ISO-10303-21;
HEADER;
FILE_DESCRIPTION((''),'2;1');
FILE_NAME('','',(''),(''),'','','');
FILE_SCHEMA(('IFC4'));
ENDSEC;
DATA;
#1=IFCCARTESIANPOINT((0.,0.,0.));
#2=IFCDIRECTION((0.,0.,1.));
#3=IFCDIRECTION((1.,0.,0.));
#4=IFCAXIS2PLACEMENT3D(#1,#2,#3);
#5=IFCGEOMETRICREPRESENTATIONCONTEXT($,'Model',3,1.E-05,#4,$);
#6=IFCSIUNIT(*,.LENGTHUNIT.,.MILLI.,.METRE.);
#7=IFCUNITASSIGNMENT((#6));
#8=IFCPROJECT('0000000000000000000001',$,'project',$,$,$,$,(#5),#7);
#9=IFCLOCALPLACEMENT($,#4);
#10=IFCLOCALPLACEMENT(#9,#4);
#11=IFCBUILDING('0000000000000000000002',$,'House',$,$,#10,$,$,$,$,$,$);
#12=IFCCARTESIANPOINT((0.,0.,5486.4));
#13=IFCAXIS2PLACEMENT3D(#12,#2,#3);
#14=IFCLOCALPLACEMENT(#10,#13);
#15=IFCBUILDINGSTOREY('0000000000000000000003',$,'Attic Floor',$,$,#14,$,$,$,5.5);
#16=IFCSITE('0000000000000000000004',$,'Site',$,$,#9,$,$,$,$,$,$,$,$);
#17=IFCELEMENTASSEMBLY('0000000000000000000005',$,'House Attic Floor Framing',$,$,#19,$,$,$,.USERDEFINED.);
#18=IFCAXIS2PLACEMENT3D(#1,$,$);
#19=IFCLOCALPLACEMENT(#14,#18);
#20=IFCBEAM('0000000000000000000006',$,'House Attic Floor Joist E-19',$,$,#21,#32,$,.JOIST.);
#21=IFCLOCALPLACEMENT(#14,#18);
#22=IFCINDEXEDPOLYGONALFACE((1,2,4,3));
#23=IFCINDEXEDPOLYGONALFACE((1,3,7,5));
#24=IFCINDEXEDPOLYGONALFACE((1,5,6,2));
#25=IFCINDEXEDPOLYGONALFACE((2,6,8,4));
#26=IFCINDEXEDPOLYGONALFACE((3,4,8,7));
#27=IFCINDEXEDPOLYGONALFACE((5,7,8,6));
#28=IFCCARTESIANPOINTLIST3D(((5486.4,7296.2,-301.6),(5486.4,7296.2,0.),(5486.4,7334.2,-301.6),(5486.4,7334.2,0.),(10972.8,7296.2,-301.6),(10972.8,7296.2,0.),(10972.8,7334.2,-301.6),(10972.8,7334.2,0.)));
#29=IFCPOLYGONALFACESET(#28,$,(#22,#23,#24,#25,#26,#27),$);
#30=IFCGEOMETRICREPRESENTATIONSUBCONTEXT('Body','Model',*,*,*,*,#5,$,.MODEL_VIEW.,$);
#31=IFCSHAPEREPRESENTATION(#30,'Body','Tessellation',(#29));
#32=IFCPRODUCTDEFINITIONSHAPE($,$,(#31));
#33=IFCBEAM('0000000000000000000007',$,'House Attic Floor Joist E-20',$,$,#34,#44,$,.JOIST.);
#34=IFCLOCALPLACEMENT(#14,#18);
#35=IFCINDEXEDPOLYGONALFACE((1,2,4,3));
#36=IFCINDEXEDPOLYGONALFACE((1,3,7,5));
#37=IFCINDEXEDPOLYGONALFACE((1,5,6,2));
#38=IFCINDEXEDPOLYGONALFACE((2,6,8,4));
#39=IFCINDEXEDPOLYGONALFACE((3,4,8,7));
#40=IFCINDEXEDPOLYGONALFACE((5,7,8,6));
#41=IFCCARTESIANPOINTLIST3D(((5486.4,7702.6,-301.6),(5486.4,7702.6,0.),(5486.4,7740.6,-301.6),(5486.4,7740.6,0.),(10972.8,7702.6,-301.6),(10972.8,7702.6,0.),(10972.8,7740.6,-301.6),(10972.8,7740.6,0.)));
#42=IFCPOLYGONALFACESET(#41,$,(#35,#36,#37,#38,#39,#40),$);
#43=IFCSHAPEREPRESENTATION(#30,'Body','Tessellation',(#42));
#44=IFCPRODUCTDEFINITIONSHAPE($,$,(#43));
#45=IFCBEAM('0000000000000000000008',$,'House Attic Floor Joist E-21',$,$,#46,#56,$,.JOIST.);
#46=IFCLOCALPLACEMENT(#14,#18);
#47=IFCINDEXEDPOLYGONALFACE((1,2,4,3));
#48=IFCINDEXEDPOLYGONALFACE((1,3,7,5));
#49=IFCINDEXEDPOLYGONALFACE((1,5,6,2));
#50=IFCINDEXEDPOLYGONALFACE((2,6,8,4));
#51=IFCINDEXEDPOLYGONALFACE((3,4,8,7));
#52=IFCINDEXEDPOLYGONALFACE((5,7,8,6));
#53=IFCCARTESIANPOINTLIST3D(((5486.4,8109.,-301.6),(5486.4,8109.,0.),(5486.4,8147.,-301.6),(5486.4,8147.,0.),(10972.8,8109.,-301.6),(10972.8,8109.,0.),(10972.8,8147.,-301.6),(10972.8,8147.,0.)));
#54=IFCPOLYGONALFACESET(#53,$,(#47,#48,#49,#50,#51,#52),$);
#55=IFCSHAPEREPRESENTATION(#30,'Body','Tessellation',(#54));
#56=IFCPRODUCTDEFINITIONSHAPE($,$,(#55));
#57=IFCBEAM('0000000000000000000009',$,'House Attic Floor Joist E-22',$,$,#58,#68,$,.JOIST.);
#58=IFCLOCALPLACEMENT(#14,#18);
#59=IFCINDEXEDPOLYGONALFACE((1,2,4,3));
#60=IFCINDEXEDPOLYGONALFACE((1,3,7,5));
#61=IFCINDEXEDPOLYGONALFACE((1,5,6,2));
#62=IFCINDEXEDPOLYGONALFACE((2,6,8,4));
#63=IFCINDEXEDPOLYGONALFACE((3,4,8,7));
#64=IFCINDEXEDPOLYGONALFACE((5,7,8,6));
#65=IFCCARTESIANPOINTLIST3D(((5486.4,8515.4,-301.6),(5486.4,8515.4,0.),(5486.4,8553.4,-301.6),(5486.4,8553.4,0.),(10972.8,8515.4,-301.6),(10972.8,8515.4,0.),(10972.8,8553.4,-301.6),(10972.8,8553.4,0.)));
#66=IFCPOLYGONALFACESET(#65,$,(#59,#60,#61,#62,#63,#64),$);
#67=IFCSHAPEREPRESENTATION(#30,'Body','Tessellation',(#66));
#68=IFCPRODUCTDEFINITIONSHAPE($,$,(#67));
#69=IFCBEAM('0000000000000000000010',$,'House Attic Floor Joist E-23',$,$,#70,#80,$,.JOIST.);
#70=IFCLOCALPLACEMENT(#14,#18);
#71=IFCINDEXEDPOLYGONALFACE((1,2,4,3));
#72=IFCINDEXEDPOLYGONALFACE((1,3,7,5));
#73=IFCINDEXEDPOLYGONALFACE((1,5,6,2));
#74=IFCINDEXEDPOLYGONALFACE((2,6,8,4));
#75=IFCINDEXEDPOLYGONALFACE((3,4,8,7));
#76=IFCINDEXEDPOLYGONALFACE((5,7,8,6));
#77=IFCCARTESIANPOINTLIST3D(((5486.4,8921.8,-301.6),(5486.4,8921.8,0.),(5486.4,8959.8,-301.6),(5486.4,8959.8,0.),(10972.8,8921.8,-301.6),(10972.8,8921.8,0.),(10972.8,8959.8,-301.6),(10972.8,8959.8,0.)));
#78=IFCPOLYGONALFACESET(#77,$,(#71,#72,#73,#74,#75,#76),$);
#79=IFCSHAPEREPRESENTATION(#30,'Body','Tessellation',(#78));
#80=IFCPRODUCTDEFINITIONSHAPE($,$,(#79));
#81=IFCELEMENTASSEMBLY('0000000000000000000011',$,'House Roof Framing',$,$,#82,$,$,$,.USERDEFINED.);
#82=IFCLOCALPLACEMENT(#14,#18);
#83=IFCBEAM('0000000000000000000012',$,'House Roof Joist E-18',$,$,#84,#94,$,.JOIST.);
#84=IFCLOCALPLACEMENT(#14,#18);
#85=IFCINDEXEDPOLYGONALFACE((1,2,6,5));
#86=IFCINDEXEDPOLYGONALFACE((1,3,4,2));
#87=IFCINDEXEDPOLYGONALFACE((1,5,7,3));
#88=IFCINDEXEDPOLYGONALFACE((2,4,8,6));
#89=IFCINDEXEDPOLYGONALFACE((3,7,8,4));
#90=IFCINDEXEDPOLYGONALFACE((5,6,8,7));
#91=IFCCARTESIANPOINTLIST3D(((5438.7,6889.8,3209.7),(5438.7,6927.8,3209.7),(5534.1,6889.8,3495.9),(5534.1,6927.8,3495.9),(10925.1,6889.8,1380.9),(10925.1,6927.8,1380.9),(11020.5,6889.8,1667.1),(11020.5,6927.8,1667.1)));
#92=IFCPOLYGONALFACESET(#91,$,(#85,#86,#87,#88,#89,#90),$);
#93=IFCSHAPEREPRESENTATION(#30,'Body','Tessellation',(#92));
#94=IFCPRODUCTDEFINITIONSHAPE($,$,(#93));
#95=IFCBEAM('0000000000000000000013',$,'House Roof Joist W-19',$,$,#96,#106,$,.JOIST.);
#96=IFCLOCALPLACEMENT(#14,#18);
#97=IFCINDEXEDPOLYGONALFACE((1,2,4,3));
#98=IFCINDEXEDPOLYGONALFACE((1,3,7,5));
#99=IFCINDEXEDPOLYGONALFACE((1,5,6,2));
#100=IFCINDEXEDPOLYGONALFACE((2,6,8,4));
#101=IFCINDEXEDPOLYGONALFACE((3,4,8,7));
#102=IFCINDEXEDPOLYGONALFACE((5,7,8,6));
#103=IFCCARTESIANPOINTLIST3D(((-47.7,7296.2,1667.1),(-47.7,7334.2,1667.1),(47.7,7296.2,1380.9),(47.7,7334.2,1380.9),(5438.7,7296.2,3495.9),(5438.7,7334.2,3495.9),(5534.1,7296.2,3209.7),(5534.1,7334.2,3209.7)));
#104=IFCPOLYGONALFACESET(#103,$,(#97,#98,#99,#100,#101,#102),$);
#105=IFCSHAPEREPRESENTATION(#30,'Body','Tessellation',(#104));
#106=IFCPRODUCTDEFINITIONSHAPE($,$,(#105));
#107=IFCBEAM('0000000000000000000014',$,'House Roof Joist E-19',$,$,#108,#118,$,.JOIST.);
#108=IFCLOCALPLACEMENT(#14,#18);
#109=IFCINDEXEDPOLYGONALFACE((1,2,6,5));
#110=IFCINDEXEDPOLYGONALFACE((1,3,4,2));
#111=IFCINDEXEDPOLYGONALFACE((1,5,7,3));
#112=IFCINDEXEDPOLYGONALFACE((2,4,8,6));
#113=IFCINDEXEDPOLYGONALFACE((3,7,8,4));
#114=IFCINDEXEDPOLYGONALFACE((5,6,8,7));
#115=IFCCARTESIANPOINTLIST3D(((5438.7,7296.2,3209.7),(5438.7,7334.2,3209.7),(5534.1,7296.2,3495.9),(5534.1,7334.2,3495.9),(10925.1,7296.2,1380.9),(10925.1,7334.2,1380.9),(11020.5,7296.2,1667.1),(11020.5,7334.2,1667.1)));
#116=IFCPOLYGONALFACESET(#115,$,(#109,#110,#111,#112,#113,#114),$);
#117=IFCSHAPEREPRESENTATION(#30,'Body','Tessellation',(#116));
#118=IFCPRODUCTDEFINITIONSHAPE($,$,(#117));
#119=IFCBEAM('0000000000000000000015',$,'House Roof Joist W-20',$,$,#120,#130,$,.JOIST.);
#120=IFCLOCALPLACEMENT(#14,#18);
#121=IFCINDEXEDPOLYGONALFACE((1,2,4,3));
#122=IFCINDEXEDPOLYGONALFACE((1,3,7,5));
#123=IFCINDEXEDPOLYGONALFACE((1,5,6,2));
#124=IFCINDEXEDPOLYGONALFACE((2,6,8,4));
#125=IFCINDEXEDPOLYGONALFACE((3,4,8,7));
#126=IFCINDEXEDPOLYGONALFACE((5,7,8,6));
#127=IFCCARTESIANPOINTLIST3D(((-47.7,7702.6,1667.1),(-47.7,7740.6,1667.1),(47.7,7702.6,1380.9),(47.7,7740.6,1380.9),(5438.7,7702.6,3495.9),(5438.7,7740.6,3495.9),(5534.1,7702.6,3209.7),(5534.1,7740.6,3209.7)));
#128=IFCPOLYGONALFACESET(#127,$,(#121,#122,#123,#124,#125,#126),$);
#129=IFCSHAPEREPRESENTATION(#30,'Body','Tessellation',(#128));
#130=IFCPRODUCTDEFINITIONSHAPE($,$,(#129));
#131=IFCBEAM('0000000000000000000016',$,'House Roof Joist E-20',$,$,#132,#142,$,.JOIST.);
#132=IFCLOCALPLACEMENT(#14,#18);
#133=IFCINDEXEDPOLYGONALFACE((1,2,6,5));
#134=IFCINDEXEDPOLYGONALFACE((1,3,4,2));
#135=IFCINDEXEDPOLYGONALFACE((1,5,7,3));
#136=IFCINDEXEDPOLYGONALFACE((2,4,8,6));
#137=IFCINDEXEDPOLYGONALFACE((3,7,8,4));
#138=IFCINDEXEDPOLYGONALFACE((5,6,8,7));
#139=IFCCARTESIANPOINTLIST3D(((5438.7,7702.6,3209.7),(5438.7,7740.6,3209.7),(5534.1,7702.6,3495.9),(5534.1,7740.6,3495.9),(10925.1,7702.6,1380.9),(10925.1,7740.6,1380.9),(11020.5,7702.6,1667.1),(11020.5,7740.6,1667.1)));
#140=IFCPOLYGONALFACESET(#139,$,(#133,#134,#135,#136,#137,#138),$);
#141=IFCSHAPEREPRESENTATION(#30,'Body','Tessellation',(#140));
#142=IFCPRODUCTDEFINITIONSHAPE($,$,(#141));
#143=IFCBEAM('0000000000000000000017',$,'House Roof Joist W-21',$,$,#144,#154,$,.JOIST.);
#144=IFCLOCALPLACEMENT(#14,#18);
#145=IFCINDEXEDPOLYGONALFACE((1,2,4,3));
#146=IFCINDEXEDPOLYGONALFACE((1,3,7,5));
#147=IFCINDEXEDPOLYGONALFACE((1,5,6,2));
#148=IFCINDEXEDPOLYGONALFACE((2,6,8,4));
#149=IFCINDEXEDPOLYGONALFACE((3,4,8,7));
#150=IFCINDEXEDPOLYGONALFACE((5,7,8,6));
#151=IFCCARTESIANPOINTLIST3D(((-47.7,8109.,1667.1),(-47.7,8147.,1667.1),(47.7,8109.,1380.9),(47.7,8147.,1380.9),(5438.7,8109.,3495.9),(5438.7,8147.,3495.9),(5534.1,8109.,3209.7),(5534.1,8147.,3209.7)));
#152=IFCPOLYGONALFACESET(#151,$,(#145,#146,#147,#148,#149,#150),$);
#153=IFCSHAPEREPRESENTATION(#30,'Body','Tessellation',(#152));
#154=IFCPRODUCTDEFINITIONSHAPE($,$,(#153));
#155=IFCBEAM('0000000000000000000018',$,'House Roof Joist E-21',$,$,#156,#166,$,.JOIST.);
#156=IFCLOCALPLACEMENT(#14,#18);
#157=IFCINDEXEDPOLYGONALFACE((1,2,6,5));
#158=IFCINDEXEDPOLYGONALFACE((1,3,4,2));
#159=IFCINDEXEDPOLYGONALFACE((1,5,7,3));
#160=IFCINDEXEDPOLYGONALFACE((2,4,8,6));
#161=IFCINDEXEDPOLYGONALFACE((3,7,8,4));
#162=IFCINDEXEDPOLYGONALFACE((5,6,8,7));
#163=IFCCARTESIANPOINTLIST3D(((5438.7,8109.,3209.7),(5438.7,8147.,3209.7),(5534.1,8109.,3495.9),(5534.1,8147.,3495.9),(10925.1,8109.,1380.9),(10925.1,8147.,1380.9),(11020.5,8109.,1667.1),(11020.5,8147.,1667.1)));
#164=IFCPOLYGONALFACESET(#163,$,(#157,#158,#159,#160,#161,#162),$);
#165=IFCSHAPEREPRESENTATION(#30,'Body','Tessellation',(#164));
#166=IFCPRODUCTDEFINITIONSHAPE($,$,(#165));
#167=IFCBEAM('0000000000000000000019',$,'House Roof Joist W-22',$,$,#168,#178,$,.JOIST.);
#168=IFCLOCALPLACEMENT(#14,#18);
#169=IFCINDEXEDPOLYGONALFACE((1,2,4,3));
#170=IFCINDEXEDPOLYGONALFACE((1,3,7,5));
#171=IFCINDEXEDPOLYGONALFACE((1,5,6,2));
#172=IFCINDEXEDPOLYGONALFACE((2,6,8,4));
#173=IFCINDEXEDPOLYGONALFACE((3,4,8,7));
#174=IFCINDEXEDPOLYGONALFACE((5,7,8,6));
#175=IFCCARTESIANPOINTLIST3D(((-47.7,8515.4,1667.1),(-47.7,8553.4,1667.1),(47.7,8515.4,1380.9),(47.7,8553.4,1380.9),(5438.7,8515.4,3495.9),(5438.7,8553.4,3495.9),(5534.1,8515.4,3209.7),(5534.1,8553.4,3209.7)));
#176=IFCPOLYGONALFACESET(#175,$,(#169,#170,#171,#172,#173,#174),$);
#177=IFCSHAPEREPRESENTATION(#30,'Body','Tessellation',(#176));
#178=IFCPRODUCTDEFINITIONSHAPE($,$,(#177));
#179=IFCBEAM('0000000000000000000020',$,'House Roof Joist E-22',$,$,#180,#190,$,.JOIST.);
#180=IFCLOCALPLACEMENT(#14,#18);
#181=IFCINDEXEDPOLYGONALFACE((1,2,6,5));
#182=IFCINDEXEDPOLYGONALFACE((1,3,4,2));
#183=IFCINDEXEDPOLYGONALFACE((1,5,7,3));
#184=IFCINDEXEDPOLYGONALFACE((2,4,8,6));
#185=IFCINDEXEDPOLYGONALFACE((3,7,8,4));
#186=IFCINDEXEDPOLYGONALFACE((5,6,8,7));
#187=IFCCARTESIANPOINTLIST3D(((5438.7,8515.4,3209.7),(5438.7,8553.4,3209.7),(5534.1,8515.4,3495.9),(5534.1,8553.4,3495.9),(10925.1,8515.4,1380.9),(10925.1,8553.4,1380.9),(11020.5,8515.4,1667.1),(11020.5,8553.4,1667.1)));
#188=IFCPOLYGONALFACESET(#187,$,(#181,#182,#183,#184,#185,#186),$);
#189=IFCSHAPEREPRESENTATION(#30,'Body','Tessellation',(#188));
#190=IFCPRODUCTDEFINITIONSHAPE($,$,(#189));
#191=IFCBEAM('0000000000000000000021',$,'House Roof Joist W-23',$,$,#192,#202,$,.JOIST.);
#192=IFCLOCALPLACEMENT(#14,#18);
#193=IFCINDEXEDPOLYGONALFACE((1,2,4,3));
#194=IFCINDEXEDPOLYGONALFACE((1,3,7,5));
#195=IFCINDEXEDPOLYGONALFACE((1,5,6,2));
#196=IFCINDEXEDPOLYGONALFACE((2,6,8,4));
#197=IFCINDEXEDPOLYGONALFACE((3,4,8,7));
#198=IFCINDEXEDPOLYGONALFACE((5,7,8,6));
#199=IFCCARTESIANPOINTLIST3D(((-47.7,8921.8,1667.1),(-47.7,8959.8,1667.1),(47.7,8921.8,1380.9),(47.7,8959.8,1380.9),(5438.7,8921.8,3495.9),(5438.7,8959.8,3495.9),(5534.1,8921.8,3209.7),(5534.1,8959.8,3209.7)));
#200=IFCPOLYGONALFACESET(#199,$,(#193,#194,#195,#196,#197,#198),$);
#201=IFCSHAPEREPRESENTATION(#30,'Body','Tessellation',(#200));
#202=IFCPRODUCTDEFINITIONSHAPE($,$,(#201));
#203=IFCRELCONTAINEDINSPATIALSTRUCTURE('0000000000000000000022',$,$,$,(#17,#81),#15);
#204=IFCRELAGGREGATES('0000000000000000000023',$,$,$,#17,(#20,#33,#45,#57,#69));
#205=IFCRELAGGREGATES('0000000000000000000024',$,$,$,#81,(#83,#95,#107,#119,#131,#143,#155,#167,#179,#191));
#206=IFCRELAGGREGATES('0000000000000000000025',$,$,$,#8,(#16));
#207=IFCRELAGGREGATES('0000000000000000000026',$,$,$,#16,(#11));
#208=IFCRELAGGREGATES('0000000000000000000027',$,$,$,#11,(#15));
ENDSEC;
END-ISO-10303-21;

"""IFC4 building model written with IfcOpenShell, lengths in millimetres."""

from ifc_helpers import new_model, si_unit, frame, origin_with_axes, origin_2d, place, context, subcontext, project, spatial, rectangle, extrude, element, aggregate, save


model = new_model("IFC4")

# Units and contexts
model_context = context("Model", 3, precision=1e-05, world=origin_with_axes())
body_context = subcontext(model_context, "Body", "Model", "MODEL_VIEW")
ifc_project = project(units=[si_unit("LENGTHUNIT", "METRE", prefix="MILLI")], contexts=[model_context])

# Site, building, storey
site_placement = place(None, origin_with_axes())
site = spatial("IfcSite", under=ifc_project, at=site_placement, Name="Site")
building_placement = place(site_placement, origin_with_axes())
building = spatial("IfcBuilding", under=site, at=building_placement, Name="House")
storey_placement = place(building_placement, frame((0.0, 0.0, 5486.4), z_axis=(0.0, 0.0, 1.0), x_axis=(1.0, 0.0, 0.0)))
storey = spatial("IfcBuildingStorey", under=building, at=storey_placement, Name="Attic Floor", Elevation=5.5)

# Element assemblies, beams
assembly_1_placement = place(storey_placement, frame((0.0, 0.0, -5486.4), z_axis=(0.0, 0.0, 1.0), x_axis=(1.0, 0.0, 0.0)))
assembly_1 = element("IfcElementAssembly", 1, at=assembly_1_placement, inside=storey, Name="House Attic Floor Framing", PredefinedType="USERDEFINED")
beam_1_placement = place(assembly_1_placement, frame((5486.4, 7315.2, 5335.6), z_axis=(1.0, 0.0, 0.0), x_axis=(0.0, 1.0, 0.0)))
beam_1 = element("IfcBeam", 2, at=beam_1_placement, Name="House Attic Floor Joist E-19", PredefinedType="JOIST", context=body_context, shape_type="SweptSolid", body=[
    extrude(rectangle(XDim=38.1, YDim=301.6, at=origin_2d()), origin_with_axes(), (0.0, 0.0, 1.0), 5486.4),
])
beam_2_placement = place(assembly_1_placement, frame((5486.4, 7721.6, 5335.6), z_axis=(1.0, 0.0, 0.0), x_axis=(0.0, 1.0, 0.0)))
beam_2 = element("IfcBeam", 3, at=beam_2_placement, Name="House Attic Floor Joist E-20", PredefinedType="JOIST", context=body_context, shape_type="SweptSolid", body=[
    extrude(rectangle(XDim=38.1, YDim=301.6, at=origin_2d()), origin_with_axes(), (0.0, 0.0, 1.0), 5486.4),
])
beam_3_placement = place(assembly_1_placement, frame((5486.4, 8128.0, 5335.6), z_axis=(1.0, 0.0, 0.0), x_axis=(0.0, 1.0, 0.0)))
beam_3 = element("IfcBeam", 4, at=beam_3_placement, Name="House Attic Floor Joist E-21", PredefinedType="JOIST", context=body_context, shape_type="SweptSolid", body=[
    extrude(rectangle(XDim=38.1, YDim=301.6, at=origin_2d()), origin_with_axes(), (0.0, 0.0, 1.0), 5486.4),
])
beam_4_placement = place(assembly_1_placement, frame((5486.4, 8534.4, 5335.6), z_axis=(1.0, 0.0, 0.0), x_axis=(0.0, 1.0, 0.0)))
beam_4 = element("IfcBeam", 5, at=beam_4_placement, Name="House Attic Floor Joist E-22", PredefinedType="JOIST", context=body_context, shape_type="SweptSolid", body=[
    extrude(rectangle(XDim=38.1, YDim=301.6, at=origin_2d()), origin_with_axes(), (0.0, 0.0, 1.0), 5486.4),
])
beam_5_placement = place(assembly_1_placement, frame((5486.4, 8940.8, 5335.6), z_axis=(1.0, 0.0, 0.0), x_axis=(0.0, 1.0, 0.0)))
beam_5 = element("IfcBeam", 6, at=beam_5_placement, Name="House Attic Floor Joist E-23", PredefinedType="JOIST", context=body_context, shape_type="SweptSolid", body=[
    extrude(rectangle(XDim=38.1, YDim=301.6, at=origin_2d()), origin_with_axes(), (0.0, 0.0, 1.0), 5486.4),
])
aggregate(assembly_1, [beam_1, beam_2, beam_3, beam_4, beam_5])
assembly_2_placement = place(storey_placement, frame((0.0, 0.0, -5486.4), z_axis=(0.0, 0.0, 1.0), x_axis=(1.0, 0.0, 0.0)))
assembly_2 = element("IfcElementAssembly", 7, at=assembly_2_placement, inside=storey, Name="House Roof Framing", PredefinedType="USERDEFINED")
beam_6_placement = place(assembly_2_placement, frame((5486.4, 6908.8, 8839.2), z_axis=(0.948683, 0.0, -0.316228), x_axis=(0.0, 1.0, 0.0)))
beam_6 = element("IfcBeam", 8, at=beam_6_placement, Name="House Roof Joist E-18", PredefinedType="JOIST", context=body_context, shape_type="SweptSolid", body=[
    extrude(rectangle(XDim=38.1, YDim=301.6, at=origin_2d()), origin_with_axes(), (0.0, 0.0, 1.0), 5783.2),
])
beam_7_placement = place(assembly_2_placement, frame((5486.4, 7315.2, 8839.2), z_axis=(-0.948683, 0.0, -0.316228), x_axis=(0.0, 1.0, 0.0)))
beam_7 = element("IfcBeam", 9, at=beam_7_placement, Name="House Roof Joist W-19", PredefinedType="JOIST", context=body_context, shape_type="SweptSolid", body=[
    extrude(rectangle(XDim=38.1, YDim=301.6, at=origin_2d()), origin_with_axes(), (0.0, 0.0, 1.0), 5783.2),
])
beam_8_placement = place(assembly_2_placement, frame((5486.4, 7315.2, 8839.2), z_axis=(0.948683, 0.0, -0.316228), x_axis=(0.0, 1.0, 0.0)))
beam_8 = element("IfcBeam", 10, at=beam_8_placement, Name="House Roof Joist E-19", PredefinedType="JOIST", context=body_context, shape_type="SweptSolid", body=[
    extrude(rectangle(XDim=38.1, YDim=301.6, at=origin_2d()), origin_with_axes(), (0.0, 0.0, 1.0), 5783.2),
])
beam_9_placement = place(assembly_2_placement, frame((5486.4, 7721.6, 8839.2), z_axis=(-0.948683, 0.0, -0.316228), x_axis=(0.0, 1.0, 0.0)))
beam_9 = element("IfcBeam", 11, at=beam_9_placement, Name="House Roof Joist W-20", PredefinedType="JOIST", context=body_context, shape_type="SweptSolid", body=[
    extrude(rectangle(XDim=38.1, YDim=301.6, at=origin_2d()), origin_with_axes(), (0.0, 0.0, 1.0), 5783.2),
])
beam_10_placement = place(assembly_2_placement, frame((5486.4, 7721.6, 8839.2), z_axis=(0.948683, 0.0, -0.316228), x_axis=(0.0, 1.0, 0.0)))
beam_10 = element("IfcBeam", 12, at=beam_10_placement, Name="House Roof Joist E-20", PredefinedType="JOIST", context=body_context, shape_type="SweptSolid", body=[
    extrude(rectangle(XDim=38.1, YDim=301.6, at=origin_2d()), origin_with_axes(), (0.0, 0.0, 1.0), 5783.2),
])
beam_11_placement = place(assembly_2_placement, frame((5486.4, 8128.0, 8839.2), z_axis=(-0.948683, 0.0, -0.316228), x_axis=(0.0, 1.0, 0.0)))
beam_11 = element("IfcBeam", 13, at=beam_11_placement, Name="House Roof Joist W-21", PredefinedType="JOIST", context=body_context, shape_type="SweptSolid", body=[
    extrude(rectangle(XDim=38.1, YDim=301.6, at=origin_2d()), origin_with_axes(), (0.0, 0.0, 1.0), 5783.2),
])
beam_12_placement = place(assembly_2_placement, frame((5486.4, 8128.0, 8839.2), z_axis=(0.948683, 0.0, -0.316228), x_axis=(0.0, 1.0, 0.0)))
beam_12 = element("IfcBeam", 14, at=beam_12_placement, Name="House Roof Joist E-21", PredefinedType="JOIST", context=body_context, shape_type="SweptSolid", body=[
    extrude(rectangle(XDim=38.1, YDim=301.6, at=origin_2d()), origin_with_axes(), (0.0, 0.0, 1.0), 5783.2),
])
beam_13_placement = place(assembly_2_placement, frame((5486.4, 8534.4, 8839.2), z_axis=(-0.948683, 0.0, -0.316228), x_axis=(0.0, 1.0, 0.0)))
beam_13 = element("IfcBeam", 15, at=beam_13_placement, Name="House Roof Joist W-22", PredefinedType="JOIST", context=body_context, shape_type="SweptSolid", body=[
    extrude(rectangle(XDim=38.1, YDim=301.6, at=origin_2d()), origin_with_axes(), (0.0, 0.0, 1.0), 5783.2),
])
beam_14_placement = place(assembly_2_placement, frame((5486.4, 8534.4, 8839.2), z_axis=(0.948683, 0.0, -0.316228), x_axis=(0.0, 1.0, 0.0)))
beam_14 = element("IfcBeam", 16, at=beam_14_placement, Name="House Roof Joist E-22", PredefinedType="JOIST", context=body_context, shape_type="SweptSolid", body=[
    extrude(rectangle(XDim=38.1, YDim=301.6, at=origin_2d()), origin_with_axes(), (0.0, 0.0, 1.0), 5783.2),
])
beam_15_placement = place(assembly_2_placement, frame((5486.4, 8940.8, 8839.2), z_axis=(-0.948683, 0.0, -0.316228), x_axis=(0.0, 1.0, 0.0)))
beam_15 = element("IfcBeam", 17, at=beam_15_placement, Name="House Roof Joist W-23", PredefinedType="JOIST", context=body_context, shape_type="SweptSolid", body=[
    extrude(rectangle(XDim=38.1, YDim=301.6, at=origin_2d()), origin_with_axes(), (0.0, 0.0, 1.0), 5783.2),
])
aggregate(assembly_2, [beam_6, beam_7, beam_8, beam_9, beam_10, beam_11, beam_12, beam_13, beam_14, beam_15])

save(model, "model.ifc")
